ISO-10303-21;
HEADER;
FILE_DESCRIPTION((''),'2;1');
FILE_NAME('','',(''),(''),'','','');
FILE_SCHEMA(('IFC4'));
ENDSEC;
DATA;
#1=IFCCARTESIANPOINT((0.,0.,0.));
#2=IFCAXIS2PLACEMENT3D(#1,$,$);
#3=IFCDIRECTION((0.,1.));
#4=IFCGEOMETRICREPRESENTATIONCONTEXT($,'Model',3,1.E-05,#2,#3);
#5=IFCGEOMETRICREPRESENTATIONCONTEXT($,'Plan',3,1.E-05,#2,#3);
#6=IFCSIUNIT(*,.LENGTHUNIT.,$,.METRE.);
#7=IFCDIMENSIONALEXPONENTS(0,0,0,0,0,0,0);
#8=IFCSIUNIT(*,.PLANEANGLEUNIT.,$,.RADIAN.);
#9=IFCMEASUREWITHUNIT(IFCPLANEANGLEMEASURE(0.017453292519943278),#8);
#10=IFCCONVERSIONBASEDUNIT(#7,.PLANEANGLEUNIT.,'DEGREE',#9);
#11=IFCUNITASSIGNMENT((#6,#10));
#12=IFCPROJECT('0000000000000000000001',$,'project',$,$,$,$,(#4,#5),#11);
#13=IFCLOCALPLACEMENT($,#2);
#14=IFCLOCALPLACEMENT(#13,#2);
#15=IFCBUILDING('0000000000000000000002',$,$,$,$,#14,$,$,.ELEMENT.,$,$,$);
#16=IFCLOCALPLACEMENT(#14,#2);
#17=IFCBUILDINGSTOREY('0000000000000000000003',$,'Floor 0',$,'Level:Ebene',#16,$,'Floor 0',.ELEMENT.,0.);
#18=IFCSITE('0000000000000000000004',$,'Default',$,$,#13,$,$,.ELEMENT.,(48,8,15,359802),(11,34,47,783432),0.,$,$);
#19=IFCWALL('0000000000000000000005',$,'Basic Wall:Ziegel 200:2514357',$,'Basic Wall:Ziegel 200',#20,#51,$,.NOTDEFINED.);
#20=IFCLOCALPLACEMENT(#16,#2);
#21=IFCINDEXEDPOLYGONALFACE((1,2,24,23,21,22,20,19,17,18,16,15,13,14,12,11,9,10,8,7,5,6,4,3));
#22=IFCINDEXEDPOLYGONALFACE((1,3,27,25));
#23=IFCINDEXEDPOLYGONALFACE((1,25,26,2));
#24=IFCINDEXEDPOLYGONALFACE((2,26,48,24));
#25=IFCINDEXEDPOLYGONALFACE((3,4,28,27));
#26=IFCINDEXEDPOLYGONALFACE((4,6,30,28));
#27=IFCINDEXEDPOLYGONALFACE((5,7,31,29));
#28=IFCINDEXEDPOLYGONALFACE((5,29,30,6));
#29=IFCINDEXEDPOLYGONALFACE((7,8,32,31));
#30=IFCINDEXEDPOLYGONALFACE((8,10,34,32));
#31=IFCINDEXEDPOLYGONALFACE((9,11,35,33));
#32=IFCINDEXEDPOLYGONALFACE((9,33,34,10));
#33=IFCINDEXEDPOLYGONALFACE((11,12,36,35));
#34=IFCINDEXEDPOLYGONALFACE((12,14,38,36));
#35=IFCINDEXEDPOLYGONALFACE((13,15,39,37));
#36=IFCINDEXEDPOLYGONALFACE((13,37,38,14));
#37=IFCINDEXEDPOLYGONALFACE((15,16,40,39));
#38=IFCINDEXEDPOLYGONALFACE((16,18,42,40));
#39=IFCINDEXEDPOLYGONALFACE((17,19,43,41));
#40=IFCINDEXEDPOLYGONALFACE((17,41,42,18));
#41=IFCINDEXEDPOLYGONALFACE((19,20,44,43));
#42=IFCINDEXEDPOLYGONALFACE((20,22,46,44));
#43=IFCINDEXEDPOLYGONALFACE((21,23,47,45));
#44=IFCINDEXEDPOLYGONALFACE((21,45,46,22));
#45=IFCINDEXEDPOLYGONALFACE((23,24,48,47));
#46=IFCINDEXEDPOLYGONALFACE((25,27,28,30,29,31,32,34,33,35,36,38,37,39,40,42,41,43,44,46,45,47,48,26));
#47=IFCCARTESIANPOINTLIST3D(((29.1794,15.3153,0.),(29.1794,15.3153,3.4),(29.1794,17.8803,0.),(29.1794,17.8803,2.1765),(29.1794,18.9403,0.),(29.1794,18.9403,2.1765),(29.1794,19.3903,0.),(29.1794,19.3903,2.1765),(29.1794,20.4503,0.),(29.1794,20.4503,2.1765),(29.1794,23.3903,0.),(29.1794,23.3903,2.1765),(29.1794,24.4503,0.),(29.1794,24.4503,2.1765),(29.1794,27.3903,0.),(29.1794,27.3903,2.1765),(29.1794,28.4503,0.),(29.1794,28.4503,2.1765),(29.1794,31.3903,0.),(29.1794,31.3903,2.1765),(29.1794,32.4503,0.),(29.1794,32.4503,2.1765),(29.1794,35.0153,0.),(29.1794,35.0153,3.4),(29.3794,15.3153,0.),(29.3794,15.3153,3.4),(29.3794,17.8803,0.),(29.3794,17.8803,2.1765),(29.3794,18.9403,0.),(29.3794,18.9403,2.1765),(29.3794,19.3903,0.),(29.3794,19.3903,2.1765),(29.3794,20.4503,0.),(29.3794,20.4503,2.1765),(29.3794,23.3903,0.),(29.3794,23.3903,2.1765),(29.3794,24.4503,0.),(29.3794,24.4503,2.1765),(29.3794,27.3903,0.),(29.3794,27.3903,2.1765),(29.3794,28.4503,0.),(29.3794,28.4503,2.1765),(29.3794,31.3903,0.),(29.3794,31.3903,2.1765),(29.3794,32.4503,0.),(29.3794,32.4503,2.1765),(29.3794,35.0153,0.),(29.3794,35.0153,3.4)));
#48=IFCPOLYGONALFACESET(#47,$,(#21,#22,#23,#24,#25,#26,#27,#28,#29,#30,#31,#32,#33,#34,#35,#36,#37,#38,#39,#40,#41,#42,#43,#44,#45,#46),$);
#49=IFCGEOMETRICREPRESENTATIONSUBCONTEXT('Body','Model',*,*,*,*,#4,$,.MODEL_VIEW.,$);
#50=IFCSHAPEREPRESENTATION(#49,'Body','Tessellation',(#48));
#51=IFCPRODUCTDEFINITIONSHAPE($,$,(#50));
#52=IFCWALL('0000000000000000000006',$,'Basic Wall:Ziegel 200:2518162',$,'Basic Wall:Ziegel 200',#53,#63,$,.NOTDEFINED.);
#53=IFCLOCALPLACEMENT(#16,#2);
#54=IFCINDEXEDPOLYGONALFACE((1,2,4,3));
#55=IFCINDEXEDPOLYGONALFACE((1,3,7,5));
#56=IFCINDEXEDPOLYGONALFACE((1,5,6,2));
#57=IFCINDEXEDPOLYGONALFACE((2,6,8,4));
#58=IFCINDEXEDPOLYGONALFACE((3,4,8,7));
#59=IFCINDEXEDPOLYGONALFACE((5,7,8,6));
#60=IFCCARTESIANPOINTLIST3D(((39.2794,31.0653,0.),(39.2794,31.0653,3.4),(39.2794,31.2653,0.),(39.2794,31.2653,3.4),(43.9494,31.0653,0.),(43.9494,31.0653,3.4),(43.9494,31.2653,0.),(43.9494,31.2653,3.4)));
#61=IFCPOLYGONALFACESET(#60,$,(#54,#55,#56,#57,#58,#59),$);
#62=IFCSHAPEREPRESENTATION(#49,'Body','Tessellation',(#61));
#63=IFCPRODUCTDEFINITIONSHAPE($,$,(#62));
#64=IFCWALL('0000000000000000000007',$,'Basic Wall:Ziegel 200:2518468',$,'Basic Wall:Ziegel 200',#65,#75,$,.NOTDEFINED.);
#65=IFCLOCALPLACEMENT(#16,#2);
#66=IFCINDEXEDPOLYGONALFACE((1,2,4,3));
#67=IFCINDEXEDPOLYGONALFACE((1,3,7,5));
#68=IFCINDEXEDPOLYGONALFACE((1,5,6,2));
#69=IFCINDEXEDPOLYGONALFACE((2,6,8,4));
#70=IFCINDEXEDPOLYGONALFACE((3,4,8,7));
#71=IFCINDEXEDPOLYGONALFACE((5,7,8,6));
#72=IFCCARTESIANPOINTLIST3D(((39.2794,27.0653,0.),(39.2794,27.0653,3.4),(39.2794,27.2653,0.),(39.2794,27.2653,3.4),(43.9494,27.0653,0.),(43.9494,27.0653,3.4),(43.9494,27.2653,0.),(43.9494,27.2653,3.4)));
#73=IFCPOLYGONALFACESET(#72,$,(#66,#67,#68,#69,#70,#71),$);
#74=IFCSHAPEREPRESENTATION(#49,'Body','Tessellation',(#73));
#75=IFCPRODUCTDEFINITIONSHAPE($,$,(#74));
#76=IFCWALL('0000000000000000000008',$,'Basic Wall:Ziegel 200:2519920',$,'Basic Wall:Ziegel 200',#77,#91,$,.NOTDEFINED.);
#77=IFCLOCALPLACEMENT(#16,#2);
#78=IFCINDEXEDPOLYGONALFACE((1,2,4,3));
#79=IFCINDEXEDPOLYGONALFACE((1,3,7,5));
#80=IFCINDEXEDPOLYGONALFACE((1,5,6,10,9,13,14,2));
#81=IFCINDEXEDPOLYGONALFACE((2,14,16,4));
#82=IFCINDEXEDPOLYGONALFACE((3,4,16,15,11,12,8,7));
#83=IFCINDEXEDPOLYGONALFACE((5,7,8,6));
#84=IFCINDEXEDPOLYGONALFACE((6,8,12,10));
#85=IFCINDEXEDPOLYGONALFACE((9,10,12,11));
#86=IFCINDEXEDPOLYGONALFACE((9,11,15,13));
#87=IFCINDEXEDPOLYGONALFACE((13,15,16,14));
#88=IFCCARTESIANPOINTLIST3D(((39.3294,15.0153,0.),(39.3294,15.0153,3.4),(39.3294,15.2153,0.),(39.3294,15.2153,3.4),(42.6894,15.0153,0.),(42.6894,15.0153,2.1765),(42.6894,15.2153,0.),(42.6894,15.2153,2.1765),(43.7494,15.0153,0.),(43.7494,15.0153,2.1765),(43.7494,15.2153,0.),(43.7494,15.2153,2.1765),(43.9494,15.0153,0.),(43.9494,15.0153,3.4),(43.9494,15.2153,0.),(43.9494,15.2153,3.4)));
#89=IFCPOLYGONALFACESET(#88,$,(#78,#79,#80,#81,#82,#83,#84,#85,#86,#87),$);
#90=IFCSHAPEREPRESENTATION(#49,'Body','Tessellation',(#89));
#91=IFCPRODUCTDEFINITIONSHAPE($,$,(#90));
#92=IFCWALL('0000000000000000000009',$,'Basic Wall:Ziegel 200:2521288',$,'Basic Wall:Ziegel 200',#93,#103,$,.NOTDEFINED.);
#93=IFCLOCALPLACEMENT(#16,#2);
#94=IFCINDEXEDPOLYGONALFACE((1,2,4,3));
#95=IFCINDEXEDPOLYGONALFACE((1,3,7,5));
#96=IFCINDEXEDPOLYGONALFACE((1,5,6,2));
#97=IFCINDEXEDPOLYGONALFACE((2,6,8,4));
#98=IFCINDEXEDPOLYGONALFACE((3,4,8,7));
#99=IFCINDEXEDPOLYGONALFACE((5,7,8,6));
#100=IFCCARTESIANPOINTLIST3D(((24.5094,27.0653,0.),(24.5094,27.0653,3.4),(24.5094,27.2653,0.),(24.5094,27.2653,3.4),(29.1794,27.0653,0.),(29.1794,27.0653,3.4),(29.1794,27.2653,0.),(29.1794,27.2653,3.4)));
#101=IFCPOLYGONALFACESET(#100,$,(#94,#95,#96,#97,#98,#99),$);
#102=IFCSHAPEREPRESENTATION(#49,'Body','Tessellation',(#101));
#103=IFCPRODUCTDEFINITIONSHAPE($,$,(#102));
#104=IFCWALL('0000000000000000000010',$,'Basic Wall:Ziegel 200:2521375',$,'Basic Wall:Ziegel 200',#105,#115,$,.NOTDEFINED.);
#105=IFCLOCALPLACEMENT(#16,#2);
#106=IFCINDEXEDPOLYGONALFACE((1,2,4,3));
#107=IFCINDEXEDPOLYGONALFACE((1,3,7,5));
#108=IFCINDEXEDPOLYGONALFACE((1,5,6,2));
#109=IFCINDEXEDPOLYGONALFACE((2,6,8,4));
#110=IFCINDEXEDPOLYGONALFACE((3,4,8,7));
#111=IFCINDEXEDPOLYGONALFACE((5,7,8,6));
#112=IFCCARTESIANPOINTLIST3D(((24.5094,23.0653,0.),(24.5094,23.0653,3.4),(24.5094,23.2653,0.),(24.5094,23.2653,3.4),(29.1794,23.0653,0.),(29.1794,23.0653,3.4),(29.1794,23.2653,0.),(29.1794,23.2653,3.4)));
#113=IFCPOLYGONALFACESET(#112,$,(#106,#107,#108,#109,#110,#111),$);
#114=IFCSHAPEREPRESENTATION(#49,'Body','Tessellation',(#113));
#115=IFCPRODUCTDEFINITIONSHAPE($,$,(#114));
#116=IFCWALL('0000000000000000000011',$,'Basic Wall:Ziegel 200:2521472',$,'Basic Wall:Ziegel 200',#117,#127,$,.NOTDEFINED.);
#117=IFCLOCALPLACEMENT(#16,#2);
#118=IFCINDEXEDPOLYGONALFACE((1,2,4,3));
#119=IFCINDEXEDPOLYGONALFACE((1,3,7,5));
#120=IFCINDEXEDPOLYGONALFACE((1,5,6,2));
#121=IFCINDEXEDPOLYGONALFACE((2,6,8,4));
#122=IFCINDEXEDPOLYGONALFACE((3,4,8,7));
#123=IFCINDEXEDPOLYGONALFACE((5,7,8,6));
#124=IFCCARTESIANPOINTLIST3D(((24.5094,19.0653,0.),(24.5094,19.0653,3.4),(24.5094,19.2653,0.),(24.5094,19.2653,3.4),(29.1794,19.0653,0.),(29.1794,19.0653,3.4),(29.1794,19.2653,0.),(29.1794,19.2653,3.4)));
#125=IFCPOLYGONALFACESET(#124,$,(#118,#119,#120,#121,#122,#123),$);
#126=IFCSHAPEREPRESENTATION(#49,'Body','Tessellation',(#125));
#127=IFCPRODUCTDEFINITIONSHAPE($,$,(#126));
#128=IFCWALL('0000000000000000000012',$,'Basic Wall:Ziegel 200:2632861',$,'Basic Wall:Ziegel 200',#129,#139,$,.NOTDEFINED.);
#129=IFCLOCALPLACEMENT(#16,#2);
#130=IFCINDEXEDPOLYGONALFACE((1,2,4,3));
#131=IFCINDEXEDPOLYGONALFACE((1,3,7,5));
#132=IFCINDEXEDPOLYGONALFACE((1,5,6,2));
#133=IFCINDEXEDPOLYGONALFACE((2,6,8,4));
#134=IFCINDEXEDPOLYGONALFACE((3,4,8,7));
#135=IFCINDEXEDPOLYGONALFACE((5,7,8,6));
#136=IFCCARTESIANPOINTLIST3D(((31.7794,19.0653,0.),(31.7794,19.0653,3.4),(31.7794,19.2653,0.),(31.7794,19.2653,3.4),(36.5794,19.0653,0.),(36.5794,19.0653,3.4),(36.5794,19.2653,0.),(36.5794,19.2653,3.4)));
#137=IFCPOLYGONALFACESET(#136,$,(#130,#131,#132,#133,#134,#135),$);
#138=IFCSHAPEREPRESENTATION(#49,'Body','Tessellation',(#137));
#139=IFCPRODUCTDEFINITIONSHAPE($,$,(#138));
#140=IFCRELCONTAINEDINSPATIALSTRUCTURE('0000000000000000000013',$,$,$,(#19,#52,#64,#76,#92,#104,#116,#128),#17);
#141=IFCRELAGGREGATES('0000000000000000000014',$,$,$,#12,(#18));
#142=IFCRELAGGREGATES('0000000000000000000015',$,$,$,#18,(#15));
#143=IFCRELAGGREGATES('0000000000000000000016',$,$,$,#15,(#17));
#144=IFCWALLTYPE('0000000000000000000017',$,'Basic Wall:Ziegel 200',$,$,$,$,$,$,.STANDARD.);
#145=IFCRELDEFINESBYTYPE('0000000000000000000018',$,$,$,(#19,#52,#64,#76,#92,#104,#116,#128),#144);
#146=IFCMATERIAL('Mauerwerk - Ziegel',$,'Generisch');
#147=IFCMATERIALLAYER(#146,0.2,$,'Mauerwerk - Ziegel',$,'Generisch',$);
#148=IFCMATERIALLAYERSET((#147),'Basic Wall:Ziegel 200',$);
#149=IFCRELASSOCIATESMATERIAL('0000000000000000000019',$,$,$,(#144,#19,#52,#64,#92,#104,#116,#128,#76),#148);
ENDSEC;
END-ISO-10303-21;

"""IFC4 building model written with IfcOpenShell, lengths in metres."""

from ifc_helpers import new_model, entity, si_unit, converted_unit, direction, frame, frame_2d, origin, place, context, subcontext, project, spatial, polyline, rectangle, extrude, clip, bounded_halfspace, material, layer, layer_set, layer_usage, type_object, element, save


model = new_model("IFC4")

# Units and contexts
model_context = context("Model", 3, precision=1e-05, world=origin(), true_north=direction((0.0, 1.0)))
plan_context = context("Plan", 3, precision=1e-05, world=origin(), true_north=direction((0.0, 1.0)))
body_context = subcontext(model_context, "Body", "Model", "MODEL_VIEW")
ifc_project = project(units=[si_unit("LENGTHUNIT", "METRE"), converted_unit("PLANEANGLEUNIT", "DEGREE", entity("IfcPlaneAngleMeasure", 0.017453292519943278), si_unit("PLANEANGLEUNIT", "RADIAN"), dimensions=[0, 0, 0, 0, 0, 0, 0])], contexts=[model_context, plan_context])

# Site, building, storey
site_placement = place(None, origin())
site = spatial("IfcSite", under=ifc_project, at=site_placement, Name="Default", CompositionType="ELEMENT", RefLatitude=(48, 8, 15, 359802), RefLongitude=(11, 34, 47, 783432), RefElevation=0.0)
building_placement = place(site_placement, origin())
building = spatial("IfcBuilding", under=site, at=building_placement, CompositionType="ELEMENT")
storey_placement = place(building_placement, origin())
storey = spatial("IfcBuildingStorey", under=building, at=storey_placement, Name="Floor 0", ObjectType="Level:Ebene", LongName="Floor 0", CompositionType="ELEMENT", Elevation=0.0)

# Shared definitions
ifc_material_1 = material(Name="Mauerwerk - Ziegel", Category="Generisch")
ifc_layer_1 = layer(ifc_material_1, 0.2, Name="Mauerwerk - Ziegel", Category="Generisch")
ifc_layer_set_1 = layer_set([ifc_layer_1], Name="Basic Wall:Ziegel 200")
ifc_layer_usage_1 = layer_usage(ifc_layer_set_1, "AXIS2", "NEGATIVE", 0.1)
wall_type_1 = type_object("IfcWallType", Name="Basic Wall:Ziegel 200", PredefinedType="STANDARD", material=ifc_layer_set_1)

# Wall, openings
wall_1_placement = place(storey_placement, frame((29.2794, 15.3153, 0.0), z_axis=(0.0, 0.0, 1.0), x_axis=(0.0, 1.0, 0.0)))
wall_1 = element("IfcWall", 1, at=wall_1_placement, inside=storey, type_object=wall_type_1, material=ifc_layer_usage_1, Name="Basic Wall:Ziegel 200:2514357", ObjectType="Basic Wall:Ziegel 200", PredefinedType="NOTDEFINED", context=body_context, shape_type="Clipping", body=[
    clip(extrude(rectangle(XDim=19.7, YDim=0.2, at=frame_2d((9.85, 0.0), x_axis=(1.0, 0.0))), origin(), (0.0, 0.0, 1.0), 3.4), bounded_halfspace(frame((0.0, -0.1, 3.4), z_axis=(0.0, 0.0, -1.0), x_axis=(0.0, 1.0, 0.0)), True, frame((0.0, -0.1, 3.4)), polyline([(0.0, 0.0), (19.7, 0.0), (19.7, 0.2), (15.95, 0.2), (15.75, 0.2), (11.95, 0.2), (11.75, 0.2), (7.95, 0.2), (7.75, 0.2), (3.95, 0.2), (3.75, 0.2), (0.0, 0.2), (0.0, 0.1), (0.0, 0.0)]))),
])
opening_1_placement = place(wall_1_placement, frame((13.135, 0.1, 0.0)))
element("IfcOpeningElement", 2, at=opening_1_placement, cuts=wall_1, PredefinedType="OPENING", context=body_context, shape_type="SweptSolid", body=[
    extrude(rectangle(XDim=2.1765, YDim=1.06, at=frame_2d((1.0882, 0.53), x_axis=(1.0, 0.0))), frame((0.0, 0.0, 0.0), z_axis=(0.0, -1.0, 0.0), x_axis=(0.0, 0.0, 1.0)), (0.0, 0.0, 1.0), 0.2),
])
opening_2_placement = place(wall_1_placement, frame((9.135, 0.1, 0.0)))
element("IfcOpeningElement", 3, at=opening_2_placement, cuts=wall_1, PredefinedType="OPENING", context=body_context, shape_type="SweptSolid", body=[
    extrude(rectangle(XDim=2.1765, YDim=1.06, at=frame_2d((1.0882, 0.53), x_axis=(1.0, 0.0))), frame((0.0, 0.0, 0.0), z_axis=(0.0, -1.0, 0.0), x_axis=(0.0, 0.0, 1.0)), (0.0, 0.0, 1.0), 0.2),
])
opening_3_placement = place(wall_1_placement, frame((5.135, 0.1, 0.0)))
element("IfcOpeningElement", 4, at=opening_3_placement, cuts=wall_1, PredefinedType="OPENING", context=body_context, shape_type="SweptSolid", body=[
    extrude(rectangle(XDim=2.1765, YDim=1.06, at=frame_2d((1.0882, 0.53), x_axis=(1.0, 0.0))), frame((0.0, 0.0, 0.0), z_axis=(0.0, -1.0, 0.0), x_axis=(0.0, 0.0, 1.0)), (0.0, 0.0, 1.0), 0.2),
])
opening_4_placement = place(wall_1_placement, frame((3.625, 0.1, 0.0)))
element("IfcOpeningElement", 5, at=opening_4_placement, cuts=wall_1, PredefinedType="OPENING", context=body_context, shape_type="SweptSolid", body=[
    extrude(rectangle(XDim=2.1765, YDim=1.06, at=frame_2d((1.0882, 0.53), x_axis=(1.0, 0.0))), frame((0.0, 0.0, 0.0), z_axis=(0.0, -1.0, 0.0), x_axis=(0.0, 0.0, 1.0)), (0.0, 0.0, 1.0), 0.2),
])
opening_5_placement = place(wall_1_placement, frame((17.135, 0.1, 0.0)))
element("IfcOpeningElement", 6, at=opening_5_placement, cuts=wall_1, PredefinedType="OPENING", context=body_context, shape_type="SweptSolid", body=[
    extrude(rectangle(XDim=2.1765, YDim=1.06, at=frame_2d((1.0882, 0.53), x_axis=(1.0, 0.0))), frame((0.0, 0.0, 0.0), z_axis=(0.0, -1.0, 0.0), x_axis=(0.0, 0.0, 1.0)), (0.0, 0.0, 1.0), 0.2),
])

# Walls
wall_2_placement = place(storey_placement, frame((39.2794, 31.1653, 0.0)))
element("IfcWall", 7, at=wall_2_placement, inside=storey, type_object=wall_type_1, material=ifc_layer_usage_1, Name="Basic Wall:Ziegel 200:2518162", ObjectType="Basic Wall:Ziegel 200", PredefinedType="NOTDEFINED", context=body_context, shape_type="Clipping", body=[
    clip(extrude(rectangle(XDim=4.67, YDim=0.2, at=frame_2d((2.335, 0.0), x_axis=(-1.0, 0.0))), origin(), (0.0, 0.0, 1.0), 3.4), bounded_halfspace(frame((0.0, -0.1, 3.4), z_axis=(0.0, 0.0, -1.0), x_axis=(-1.0, 0.0, 0.0)), True, frame((0.0, -0.1, 3.4)), polyline([(0.0, 0.0), (4.67, 0.0), (4.67, 0.2), (0.0, 0.2), (0.0, 0.0)]))),
])
wall_3_placement = place(storey_placement, frame((39.2794, 27.1653, 0.0)))
element("IfcWall", 8, at=wall_3_placement, inside=storey, type_object=wall_type_1, material=ifc_layer_usage_1, Name="Basic Wall:Ziegel 200:2518468", ObjectType="Basic Wall:Ziegel 200", PredefinedType="NOTDEFINED", context=body_context, shape_type="Clipping", body=[
    clip(extrude(rectangle(XDim=4.67, YDim=0.2, at=frame_2d((2.335, 0.0), x_axis=(-1.0, 0.0))), origin(), (0.0, 0.0, 1.0), 3.4), bounded_halfspace(frame((0.0, -0.1, 3.4), z_axis=(0.0, 0.0, -1.0), x_axis=(-1.0, 0.0, 0.0)), True, frame((0.0, -0.1, 3.4)), polyline([(0.0, 0.0), (4.67, 0.0), (4.67, 0.2), (0.0, 0.2), (0.0, 0.0)]))),
])

# Wall, opening
ifc_layer_usage_2 = layer_usage(ifc_layer_set_1, "AXIS2", "POSITIVE", -0.1)
wall_4_placement = place(storey_placement, frame((39.3294, 15.1153, 0.0)))
wall_4 = element("IfcWall", 9, at=wall_4_placement, inside=storey, type_object=wall_type_1, material=ifc_layer_usage_2, Name="Basic Wall:Ziegel 200:2519920", ObjectType="Basic Wall:Ziegel 200", PredefinedType="NOTDEFINED", context=body_context, shape_type="Clipping", body=[
    clip(extrude(rectangle(XDim=4.62, YDim=0.2, at=frame_2d((2.31, 0.0), x_axis=(-1.0, 0.0))), origin(), (0.0, 0.0, 1.0), 3.4), bounded_halfspace(frame((0.0, -0.1, 3.4), z_axis=(0.0, 0.0, -1.0), x_axis=(-1.0, 0.0, 0.0)), True, frame((0.0, -0.1, 3.4)), polyline([(0.0, 0.0), (4.62, 0.0), (4.62, 0.2), (0.0, 0.2), (0.0, 0.0)]))),
])
opening_6_placement = place(wall_4_placement, frame((4.42, 0.1, 0.0)))
element("IfcOpeningElement", 10, at=opening_6_placement, cuts=wall_4, PredefinedType="OPENING", context=body_context, shape_type="SweptSolid", body=[
    extrude(rectangle(XDim=2.1765, YDim=1.06, at=frame_2d((1.0882, 0.53), x_axis=(1.0, 0.0))), frame((0.0, 0.0, 0.0), z_axis=(0.0, -1.0, 0.0), x_axis=(0.0, 0.0, 1.0)), (0.0, 0.0, 1.0), 0.2),
])

# Walls
wall_5_placement = place(storey_placement, frame((29.1794, 27.1653, 0.0), z_axis=(0.0, 0.0, 1.0), x_axis=(-1.0, 0.0, 0.0)))
element("IfcWall", 11, at=wall_5_placement, inside=storey, type_object=wall_type_1, material=ifc_layer_usage_1, Name="Basic Wall:Ziegel 200:2521288", ObjectType="Basic Wall:Ziegel 200", PredefinedType="NOTDEFINED", context=body_context, shape_type="Clipping", body=[
    clip(extrude(rectangle(XDim=4.67, YDim=0.2, at=frame_2d((2.335, 0.0), x_axis=(-1.0, 0.0))), origin(), (0.0, 0.0, 1.0), 3.4), bounded_halfspace(frame((0.0, -0.1, 3.4), z_axis=(0.0, 0.0, -1.0), x_axis=(1.0, 0.0, 0.0)), True, frame((0.0, -0.1, 3.4)), polyline([(0.0, 0.0), (4.67, 0.0), (4.67, 0.2), (0.0, 0.2), (0.0, 0.0)]))),
])
wall_6_placement = place(storey_placement, frame((29.1794, 23.1653, 0.0), z_axis=(0.0, 0.0, 1.0), x_axis=(-1.0, 0.0, 0.0)))
element("IfcWall", 12, at=wall_6_placement, inside=storey, type_object=wall_type_1, material=ifc_layer_usage_1, Name="Basic Wall:Ziegel 200:2521375", ObjectType="Basic Wall:Ziegel 200", PredefinedType="NOTDEFINED", context=body_context, shape_type="Clipping", body=[
    clip(extrude(rectangle(XDim=4.67, YDim=0.2, at=frame_2d((2.335, 0.0), x_axis=(-1.0, 0.0))), origin(), (0.0, 0.0, 1.0), 3.4), bounded_halfspace(frame((0.0, -0.1, 3.4), z_axis=(0.0, 0.0, -1.0), x_axis=(1.0, 0.0, 0.0)), True, frame((0.0, -0.1, 3.4)), polyline([(0.0, 0.0), (4.67, 0.0), (4.67, 0.2), (0.0, 0.2), (0.0, 0.0)]))),
])
wall_7_placement = place(storey_placement, frame((29.1794, 19.1653, 0.0), z_axis=(0.0, 0.0, 1.0), x_axis=(-1.0, 0.0, 0.0)))
element("IfcWall", 13, at=wall_7_placement, inside=storey, type_object=wall_type_1, material=ifc_layer_usage_1, Name="Basic Wall:Ziegel 200:2521472", ObjectType="Basic Wall:Ziegel 200", PredefinedType="NOTDEFINED", context=body_context, shape_type="Clipping", body=[
    clip(extrude(rectangle(XDim=4.67, YDim=0.2, at=frame_2d((2.335, 0.0), x_axis=(-1.0, 0.0))), origin(), (0.0, 0.0, 1.0), 3.4), bounded_halfspace(frame((0.0, -0.1, 3.4), z_axis=(0.0, 0.0, -1.0), x_axis=(1.0, 0.0, 0.0)), True, frame((0.0, -0.1, 3.4)), polyline([(0.0, 0.0), (4.67, 0.0), (4.67, 0.2), (0.0, 0.2), (0.0, 0.0)]))),
])
wall_8_placement = place(storey_placement, frame((31.7794, 19.1653, 0.0)))
element("IfcWall", 14, at=wall_8_placement, inside=storey, type_object=wall_type_1, material=ifc_layer_usage_1, Name="Basic Wall:Ziegel 200:2632861", ObjectType="Basic Wall:Ziegel 200", PredefinedType="NOTDEFINED", context=body_context, shape_type="Clipping", body=[
    clip(extrude(rectangle(XDim=4.8, YDim=0.2, at=frame_2d((2.4, 0.0), x_axis=(-1.0, 0.0))), origin(), (0.0, 0.0, 1.0), 3.4), bounded_halfspace(frame((0.0, -0.1, 3.4), z_axis=(0.0, 0.0, -1.0), x_axis=(-1.0, 0.0, 0.0)), True, frame((0.0, -0.1, 3.4)), polyline([(0.0, 0.0), (4.8, 0.0), (4.8, 0.2), (0.0, 0.2), (0.0, 0.0)]))),
])

save(model, "model.ifc")
